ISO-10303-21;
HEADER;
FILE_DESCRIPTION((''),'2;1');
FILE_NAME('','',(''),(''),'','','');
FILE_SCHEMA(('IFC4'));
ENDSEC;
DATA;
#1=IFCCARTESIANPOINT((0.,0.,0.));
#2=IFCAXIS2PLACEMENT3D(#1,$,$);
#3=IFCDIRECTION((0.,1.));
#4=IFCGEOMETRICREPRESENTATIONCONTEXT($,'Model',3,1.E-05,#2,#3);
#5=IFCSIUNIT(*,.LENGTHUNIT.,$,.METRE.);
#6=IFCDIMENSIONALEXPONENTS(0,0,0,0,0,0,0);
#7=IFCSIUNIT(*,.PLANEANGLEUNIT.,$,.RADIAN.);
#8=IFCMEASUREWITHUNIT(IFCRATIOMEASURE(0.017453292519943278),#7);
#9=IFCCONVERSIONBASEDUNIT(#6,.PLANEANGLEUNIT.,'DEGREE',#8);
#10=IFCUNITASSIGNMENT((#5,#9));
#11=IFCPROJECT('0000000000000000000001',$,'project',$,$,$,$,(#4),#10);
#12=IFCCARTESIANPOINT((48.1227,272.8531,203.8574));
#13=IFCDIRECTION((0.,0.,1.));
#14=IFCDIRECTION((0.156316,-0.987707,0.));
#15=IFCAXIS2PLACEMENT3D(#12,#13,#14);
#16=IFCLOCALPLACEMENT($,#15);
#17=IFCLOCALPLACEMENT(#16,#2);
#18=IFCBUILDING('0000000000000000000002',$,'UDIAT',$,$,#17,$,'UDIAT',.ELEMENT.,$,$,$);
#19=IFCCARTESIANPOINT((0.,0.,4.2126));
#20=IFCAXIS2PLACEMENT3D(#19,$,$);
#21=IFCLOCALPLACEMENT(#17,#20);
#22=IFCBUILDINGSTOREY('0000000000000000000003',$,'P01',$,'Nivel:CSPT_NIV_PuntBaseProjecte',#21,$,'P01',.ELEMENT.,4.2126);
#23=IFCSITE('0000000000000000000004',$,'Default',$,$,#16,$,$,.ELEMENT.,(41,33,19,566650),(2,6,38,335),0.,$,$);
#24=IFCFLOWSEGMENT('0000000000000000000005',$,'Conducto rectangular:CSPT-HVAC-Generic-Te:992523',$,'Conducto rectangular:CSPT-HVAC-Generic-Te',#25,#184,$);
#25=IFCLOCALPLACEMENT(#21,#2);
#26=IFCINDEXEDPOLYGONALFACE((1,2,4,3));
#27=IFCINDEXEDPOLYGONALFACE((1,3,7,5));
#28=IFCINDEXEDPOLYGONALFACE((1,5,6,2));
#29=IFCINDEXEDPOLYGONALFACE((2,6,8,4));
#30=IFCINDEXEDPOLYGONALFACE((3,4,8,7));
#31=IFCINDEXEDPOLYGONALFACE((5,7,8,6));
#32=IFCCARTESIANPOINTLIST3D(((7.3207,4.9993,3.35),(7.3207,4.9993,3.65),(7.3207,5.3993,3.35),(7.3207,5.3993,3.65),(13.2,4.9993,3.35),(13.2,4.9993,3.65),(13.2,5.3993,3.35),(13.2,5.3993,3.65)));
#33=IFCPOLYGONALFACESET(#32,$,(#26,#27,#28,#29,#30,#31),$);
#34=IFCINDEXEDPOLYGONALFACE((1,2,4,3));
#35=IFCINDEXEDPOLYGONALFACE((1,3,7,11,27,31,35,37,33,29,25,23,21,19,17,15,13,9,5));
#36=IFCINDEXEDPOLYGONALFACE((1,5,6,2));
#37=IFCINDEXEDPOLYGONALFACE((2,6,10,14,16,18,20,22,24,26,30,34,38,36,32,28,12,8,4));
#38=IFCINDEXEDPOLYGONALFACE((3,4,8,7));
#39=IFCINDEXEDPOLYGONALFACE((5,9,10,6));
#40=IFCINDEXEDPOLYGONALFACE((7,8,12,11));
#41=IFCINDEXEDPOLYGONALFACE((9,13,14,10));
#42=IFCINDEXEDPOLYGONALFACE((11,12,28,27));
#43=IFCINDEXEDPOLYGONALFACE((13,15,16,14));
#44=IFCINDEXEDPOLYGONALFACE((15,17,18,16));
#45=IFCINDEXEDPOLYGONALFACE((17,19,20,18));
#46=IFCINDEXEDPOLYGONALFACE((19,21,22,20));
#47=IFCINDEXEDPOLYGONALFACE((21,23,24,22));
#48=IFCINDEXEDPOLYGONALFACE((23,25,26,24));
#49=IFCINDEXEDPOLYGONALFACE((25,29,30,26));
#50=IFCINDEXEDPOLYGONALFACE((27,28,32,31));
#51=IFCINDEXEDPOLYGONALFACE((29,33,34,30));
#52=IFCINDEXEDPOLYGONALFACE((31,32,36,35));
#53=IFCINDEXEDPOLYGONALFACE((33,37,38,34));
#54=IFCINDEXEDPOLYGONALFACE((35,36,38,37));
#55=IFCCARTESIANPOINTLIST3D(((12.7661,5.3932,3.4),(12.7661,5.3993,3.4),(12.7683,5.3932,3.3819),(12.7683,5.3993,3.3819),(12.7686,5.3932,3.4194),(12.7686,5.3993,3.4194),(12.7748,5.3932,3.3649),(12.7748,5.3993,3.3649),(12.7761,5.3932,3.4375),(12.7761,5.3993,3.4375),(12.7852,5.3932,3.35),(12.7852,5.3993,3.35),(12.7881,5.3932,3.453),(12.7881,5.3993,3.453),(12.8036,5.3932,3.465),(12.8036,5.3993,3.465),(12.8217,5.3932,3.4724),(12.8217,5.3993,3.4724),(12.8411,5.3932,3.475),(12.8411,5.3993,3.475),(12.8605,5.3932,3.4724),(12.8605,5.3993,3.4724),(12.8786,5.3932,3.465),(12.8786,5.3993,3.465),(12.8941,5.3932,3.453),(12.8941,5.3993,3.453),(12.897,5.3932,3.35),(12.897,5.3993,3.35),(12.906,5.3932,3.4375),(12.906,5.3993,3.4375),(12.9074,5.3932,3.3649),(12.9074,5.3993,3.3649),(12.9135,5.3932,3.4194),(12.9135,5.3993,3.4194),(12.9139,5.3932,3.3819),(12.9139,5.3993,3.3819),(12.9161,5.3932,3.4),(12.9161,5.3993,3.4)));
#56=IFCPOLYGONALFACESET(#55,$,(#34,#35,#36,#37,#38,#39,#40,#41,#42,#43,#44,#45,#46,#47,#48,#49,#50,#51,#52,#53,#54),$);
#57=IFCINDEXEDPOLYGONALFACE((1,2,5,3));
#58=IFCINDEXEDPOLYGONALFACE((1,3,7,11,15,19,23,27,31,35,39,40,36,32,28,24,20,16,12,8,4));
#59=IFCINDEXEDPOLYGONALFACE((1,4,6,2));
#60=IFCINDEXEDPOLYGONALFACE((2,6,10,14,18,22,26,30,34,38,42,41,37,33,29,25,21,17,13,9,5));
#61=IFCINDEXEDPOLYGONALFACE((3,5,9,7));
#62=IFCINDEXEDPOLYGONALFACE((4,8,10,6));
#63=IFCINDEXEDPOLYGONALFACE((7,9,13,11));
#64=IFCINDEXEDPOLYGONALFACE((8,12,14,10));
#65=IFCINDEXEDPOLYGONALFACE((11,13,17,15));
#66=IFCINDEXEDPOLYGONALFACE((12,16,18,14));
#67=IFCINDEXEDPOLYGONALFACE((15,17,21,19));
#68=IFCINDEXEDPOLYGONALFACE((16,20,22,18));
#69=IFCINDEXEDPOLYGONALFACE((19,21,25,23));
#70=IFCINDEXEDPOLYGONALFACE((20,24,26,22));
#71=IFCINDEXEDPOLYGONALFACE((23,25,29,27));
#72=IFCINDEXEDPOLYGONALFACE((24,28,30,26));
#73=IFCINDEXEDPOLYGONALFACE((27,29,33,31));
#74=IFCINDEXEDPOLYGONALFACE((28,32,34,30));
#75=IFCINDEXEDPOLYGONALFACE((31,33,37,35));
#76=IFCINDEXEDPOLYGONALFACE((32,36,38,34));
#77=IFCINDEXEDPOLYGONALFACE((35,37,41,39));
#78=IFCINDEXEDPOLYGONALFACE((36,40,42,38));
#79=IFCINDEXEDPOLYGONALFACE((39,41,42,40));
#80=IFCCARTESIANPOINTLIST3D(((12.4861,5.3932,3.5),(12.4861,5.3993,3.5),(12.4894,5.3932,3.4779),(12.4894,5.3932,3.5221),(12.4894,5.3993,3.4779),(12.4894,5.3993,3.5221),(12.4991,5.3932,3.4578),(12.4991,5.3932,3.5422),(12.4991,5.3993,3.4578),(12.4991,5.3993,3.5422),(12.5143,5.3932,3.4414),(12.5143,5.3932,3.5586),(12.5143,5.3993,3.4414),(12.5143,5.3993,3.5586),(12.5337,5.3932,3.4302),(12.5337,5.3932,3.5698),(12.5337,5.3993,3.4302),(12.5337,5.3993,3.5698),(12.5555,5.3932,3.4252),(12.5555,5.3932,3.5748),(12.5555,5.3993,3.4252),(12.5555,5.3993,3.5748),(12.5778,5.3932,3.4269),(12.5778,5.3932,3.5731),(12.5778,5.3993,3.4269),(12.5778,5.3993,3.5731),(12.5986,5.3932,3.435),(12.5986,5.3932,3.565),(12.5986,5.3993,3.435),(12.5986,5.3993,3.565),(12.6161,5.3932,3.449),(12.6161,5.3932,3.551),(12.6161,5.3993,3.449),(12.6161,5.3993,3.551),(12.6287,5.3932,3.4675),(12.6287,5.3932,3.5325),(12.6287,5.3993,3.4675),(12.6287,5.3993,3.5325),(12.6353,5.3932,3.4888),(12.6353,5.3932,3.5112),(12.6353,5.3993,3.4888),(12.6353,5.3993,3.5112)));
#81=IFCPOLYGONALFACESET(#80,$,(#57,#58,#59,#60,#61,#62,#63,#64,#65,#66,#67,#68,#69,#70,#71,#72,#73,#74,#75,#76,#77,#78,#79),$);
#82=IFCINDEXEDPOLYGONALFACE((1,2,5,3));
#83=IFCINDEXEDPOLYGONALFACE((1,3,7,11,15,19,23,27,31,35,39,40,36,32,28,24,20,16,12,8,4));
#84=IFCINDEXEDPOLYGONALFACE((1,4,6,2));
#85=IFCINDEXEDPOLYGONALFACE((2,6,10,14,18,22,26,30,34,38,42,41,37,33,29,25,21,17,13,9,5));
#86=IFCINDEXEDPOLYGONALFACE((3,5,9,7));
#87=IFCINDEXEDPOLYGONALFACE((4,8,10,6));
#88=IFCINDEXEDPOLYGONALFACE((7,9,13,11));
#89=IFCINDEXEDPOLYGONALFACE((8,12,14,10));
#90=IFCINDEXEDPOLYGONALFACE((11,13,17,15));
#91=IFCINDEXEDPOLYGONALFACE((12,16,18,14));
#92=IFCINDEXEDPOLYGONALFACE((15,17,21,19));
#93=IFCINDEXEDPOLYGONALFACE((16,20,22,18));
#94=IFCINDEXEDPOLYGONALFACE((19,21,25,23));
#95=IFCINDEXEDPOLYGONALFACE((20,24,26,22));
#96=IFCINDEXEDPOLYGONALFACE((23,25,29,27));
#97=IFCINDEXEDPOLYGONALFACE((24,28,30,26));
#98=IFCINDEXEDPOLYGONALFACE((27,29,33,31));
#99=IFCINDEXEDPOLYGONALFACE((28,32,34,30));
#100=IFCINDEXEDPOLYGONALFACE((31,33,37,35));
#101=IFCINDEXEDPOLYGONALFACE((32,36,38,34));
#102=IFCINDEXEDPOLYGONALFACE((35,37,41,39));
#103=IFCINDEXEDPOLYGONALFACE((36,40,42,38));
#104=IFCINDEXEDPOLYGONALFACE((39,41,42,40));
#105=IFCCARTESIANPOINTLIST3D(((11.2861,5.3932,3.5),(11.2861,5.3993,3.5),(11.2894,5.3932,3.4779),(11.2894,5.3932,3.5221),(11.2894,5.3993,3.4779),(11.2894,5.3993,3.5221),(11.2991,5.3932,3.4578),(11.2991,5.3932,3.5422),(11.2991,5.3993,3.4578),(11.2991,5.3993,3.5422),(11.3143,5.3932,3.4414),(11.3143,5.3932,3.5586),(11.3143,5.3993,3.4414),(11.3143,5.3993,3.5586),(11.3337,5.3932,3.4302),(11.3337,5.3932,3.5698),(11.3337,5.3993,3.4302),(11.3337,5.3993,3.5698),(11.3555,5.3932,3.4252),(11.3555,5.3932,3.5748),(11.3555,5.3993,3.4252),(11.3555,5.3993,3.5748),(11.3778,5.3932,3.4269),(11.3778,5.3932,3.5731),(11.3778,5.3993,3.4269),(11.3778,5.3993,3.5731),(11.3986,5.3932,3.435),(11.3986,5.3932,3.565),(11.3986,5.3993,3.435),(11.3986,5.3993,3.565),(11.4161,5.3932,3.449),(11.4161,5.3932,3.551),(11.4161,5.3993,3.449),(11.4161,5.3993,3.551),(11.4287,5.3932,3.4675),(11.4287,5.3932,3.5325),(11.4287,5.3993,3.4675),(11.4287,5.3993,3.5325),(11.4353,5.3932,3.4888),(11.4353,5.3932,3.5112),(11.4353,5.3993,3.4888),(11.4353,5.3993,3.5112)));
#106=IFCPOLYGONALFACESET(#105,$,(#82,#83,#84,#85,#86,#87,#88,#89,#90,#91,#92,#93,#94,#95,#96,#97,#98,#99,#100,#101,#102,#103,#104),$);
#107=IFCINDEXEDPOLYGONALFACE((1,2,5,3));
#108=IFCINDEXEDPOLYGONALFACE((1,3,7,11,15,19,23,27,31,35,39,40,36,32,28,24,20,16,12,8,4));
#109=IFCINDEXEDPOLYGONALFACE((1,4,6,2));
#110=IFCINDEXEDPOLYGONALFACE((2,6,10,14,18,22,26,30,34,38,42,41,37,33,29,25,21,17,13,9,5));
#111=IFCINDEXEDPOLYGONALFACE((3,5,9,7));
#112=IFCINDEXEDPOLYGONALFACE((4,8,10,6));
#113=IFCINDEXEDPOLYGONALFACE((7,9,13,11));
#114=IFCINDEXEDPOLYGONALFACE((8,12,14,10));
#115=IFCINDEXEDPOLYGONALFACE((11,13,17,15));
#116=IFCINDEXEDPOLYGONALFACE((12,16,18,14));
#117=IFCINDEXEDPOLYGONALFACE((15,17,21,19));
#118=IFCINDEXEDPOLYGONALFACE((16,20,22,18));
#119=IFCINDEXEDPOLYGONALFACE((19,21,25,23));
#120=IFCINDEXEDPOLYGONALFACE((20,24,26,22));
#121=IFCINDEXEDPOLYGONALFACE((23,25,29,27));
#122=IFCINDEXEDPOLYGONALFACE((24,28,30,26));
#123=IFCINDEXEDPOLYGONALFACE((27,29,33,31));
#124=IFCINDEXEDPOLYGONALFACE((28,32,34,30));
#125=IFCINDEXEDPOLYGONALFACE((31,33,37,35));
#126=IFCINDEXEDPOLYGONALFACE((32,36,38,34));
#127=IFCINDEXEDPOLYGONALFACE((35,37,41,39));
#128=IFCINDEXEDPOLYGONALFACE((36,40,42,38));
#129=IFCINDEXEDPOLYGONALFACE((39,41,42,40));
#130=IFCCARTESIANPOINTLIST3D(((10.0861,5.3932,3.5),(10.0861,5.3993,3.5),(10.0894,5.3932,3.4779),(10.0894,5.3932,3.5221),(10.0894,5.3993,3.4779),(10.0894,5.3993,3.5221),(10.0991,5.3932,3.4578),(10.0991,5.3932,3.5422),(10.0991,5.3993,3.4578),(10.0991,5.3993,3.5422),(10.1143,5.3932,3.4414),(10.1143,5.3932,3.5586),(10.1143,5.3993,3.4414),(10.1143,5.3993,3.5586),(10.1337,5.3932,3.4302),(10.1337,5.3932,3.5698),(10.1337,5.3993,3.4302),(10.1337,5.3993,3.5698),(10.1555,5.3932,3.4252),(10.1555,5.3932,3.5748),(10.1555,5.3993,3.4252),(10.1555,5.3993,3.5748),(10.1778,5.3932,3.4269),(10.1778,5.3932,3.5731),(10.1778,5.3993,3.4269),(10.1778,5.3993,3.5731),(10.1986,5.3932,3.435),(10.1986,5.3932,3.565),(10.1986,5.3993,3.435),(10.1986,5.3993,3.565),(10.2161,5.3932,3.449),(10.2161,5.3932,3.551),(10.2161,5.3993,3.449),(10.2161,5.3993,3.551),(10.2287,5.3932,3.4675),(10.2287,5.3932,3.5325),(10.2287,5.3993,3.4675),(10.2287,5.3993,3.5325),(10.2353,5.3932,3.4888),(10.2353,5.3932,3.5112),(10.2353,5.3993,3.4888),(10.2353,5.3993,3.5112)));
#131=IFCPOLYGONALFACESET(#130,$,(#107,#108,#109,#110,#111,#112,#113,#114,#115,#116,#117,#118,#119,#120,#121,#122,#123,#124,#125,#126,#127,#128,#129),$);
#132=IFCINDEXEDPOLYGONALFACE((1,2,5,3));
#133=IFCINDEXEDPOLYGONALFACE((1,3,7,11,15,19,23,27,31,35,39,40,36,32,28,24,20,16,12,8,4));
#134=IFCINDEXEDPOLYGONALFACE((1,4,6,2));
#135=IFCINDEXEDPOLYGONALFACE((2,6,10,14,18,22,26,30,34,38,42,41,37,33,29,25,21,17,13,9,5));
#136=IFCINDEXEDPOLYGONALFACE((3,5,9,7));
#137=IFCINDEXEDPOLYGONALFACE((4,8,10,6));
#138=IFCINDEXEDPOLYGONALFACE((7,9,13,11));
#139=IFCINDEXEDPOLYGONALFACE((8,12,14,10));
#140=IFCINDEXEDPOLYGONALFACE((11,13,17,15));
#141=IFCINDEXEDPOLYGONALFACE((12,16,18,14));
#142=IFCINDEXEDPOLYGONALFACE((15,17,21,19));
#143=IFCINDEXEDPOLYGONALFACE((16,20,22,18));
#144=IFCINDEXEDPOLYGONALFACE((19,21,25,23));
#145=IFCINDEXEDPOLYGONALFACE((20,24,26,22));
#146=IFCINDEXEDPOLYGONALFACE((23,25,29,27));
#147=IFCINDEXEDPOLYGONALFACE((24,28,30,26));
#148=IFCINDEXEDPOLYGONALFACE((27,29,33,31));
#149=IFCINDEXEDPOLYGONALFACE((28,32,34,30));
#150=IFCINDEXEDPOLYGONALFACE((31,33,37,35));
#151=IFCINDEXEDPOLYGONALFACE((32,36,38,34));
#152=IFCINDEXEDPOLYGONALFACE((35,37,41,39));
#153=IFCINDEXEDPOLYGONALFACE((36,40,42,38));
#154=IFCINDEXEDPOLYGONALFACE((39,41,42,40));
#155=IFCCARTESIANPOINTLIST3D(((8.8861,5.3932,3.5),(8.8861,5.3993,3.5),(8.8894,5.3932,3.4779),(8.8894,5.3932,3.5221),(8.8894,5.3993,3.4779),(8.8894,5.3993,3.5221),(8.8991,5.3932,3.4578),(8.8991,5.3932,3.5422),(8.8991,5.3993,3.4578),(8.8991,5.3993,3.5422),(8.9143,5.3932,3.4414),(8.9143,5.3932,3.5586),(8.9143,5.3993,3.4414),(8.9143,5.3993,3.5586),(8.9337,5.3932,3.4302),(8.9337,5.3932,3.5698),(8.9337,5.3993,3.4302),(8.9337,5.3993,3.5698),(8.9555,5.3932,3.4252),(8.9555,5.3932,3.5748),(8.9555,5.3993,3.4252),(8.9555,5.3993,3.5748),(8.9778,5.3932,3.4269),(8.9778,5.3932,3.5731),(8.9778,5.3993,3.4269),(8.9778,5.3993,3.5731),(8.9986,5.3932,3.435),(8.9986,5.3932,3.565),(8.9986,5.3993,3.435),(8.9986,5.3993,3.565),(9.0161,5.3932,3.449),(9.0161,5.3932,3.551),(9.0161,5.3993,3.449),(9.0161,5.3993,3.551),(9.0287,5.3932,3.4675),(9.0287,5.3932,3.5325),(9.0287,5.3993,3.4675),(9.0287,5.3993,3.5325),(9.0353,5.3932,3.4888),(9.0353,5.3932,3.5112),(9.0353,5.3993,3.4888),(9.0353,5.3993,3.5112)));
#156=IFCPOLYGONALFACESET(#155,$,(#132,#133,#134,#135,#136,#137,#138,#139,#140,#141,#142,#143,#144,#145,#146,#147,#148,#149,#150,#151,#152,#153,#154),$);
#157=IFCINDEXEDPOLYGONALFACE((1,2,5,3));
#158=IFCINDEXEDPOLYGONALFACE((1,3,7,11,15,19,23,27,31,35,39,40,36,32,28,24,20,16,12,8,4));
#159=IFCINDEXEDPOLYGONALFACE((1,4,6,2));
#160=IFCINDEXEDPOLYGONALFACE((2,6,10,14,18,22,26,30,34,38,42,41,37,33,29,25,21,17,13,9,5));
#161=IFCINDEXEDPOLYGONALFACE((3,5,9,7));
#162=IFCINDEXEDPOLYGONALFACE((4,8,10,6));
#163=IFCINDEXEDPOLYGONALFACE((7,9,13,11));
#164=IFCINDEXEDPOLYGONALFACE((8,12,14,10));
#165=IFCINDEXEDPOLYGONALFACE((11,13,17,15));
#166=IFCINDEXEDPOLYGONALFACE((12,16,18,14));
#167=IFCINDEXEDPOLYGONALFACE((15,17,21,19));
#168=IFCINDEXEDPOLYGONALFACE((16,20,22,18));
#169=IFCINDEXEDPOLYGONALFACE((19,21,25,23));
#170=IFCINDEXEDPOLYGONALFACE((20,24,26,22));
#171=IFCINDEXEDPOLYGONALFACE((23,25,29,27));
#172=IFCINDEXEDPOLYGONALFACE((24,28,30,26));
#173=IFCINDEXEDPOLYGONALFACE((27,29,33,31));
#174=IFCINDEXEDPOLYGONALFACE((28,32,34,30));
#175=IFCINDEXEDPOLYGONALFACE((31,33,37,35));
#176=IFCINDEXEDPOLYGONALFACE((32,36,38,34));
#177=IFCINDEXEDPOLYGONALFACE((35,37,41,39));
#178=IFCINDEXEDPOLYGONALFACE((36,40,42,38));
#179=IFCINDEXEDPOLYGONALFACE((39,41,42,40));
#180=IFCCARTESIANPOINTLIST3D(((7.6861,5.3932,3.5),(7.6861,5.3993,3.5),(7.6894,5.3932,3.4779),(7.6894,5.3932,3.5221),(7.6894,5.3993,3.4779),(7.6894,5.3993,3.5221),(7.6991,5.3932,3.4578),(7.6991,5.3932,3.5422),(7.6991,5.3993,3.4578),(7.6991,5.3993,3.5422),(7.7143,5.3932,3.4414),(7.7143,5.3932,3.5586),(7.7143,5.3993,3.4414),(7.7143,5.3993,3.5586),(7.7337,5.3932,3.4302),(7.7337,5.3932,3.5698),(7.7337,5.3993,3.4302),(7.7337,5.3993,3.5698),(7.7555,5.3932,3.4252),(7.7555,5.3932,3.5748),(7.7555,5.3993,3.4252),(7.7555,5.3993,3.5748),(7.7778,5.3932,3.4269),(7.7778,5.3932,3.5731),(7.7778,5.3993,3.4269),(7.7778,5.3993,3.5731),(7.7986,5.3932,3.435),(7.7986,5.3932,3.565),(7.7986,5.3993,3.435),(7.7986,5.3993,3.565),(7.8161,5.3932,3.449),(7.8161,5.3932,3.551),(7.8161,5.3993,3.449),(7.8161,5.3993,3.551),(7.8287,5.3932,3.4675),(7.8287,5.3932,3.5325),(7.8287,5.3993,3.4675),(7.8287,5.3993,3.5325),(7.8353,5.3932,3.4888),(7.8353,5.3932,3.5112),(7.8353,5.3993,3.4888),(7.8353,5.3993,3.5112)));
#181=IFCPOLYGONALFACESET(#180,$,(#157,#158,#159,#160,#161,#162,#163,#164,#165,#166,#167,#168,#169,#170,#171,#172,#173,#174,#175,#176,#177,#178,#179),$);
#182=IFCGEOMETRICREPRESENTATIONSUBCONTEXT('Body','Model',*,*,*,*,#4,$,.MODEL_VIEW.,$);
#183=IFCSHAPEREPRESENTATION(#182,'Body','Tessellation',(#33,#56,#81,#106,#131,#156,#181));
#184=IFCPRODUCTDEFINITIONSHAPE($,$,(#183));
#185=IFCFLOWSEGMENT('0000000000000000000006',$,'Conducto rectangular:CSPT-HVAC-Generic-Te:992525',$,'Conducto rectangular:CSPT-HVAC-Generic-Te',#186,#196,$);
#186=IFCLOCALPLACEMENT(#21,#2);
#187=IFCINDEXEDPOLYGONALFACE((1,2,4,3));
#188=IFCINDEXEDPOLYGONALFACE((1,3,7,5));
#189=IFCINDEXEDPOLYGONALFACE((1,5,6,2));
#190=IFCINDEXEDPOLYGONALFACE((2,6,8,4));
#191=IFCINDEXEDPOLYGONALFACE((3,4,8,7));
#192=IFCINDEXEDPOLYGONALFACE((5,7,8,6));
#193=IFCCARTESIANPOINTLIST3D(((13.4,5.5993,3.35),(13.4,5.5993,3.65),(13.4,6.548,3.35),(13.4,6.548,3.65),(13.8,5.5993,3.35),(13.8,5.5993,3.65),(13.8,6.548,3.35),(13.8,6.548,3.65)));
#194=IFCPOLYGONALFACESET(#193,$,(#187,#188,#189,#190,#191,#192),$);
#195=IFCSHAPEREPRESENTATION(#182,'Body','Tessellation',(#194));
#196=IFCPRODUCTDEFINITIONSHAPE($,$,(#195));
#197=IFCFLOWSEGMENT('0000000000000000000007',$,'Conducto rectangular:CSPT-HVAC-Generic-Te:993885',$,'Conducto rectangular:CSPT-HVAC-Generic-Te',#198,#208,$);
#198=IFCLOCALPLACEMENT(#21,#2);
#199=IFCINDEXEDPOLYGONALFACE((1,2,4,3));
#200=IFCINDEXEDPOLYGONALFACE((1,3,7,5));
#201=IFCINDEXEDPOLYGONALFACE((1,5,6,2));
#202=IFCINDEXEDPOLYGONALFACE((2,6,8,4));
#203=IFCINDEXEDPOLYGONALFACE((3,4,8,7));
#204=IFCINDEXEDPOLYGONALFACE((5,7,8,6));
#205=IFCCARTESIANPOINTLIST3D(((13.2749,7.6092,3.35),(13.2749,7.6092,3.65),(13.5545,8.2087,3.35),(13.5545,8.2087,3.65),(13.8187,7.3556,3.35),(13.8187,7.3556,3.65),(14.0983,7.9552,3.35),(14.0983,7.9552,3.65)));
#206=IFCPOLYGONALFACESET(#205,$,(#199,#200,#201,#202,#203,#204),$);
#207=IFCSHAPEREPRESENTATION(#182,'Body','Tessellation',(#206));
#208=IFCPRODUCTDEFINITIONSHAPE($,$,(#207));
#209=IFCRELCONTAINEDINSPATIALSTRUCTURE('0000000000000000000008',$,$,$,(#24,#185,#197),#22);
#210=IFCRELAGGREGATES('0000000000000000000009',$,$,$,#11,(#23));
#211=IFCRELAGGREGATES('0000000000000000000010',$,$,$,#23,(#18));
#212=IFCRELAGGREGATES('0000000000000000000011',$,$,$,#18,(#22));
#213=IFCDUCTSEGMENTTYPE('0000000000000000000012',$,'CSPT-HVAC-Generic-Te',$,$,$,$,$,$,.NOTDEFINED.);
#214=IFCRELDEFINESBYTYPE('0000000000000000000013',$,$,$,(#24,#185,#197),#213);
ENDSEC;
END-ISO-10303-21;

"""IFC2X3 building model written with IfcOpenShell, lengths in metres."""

from ifc_helpers import new_model, entity, si_unit, converted_unit, direction, frame, frame_2d, origin, origin_2d_with_axis, place, context, subcontext, project, spatial, polyline, circle_curve, parameter, trimmed, segment, composite_curve, rectangle, circle, outline, extrude, type_object, element, save


model = new_model("IFC2X3")

# Units and contexts
model_context = context("Model", 3, precision=1e-05, world=origin(), true_north=direction((0.0, 1.0)))
body_context = subcontext(model_context, "Body", "Model", "MODEL_VIEW")
ifc_project = project(units=[si_unit("LENGTHUNIT", "METRE"), converted_unit("PLANEANGLEUNIT", "DEGREE", entity("IfcRatioMeasure", 0.017453292519943278), si_unit("PLANEANGLEUNIT", "RADIAN"), dimensions=[0, 0, 0, 0, 0, 0, 0])], contexts=[model_context])

# Site, building, storey
site_placement = place(None, frame((48.1227, 272.8531, 203.8574), z_axis=(0.0, 0.0, 1.0), x_axis=(0.156316, -0.987707, 0.0)))
site = spatial("IfcSite", under=ifc_project, at=site_placement, Name="Default", CompositionType="ELEMENT", RefLatitude=(41, 33, 19, 566650), RefLongitude=(2, 6, 38, 335), RefElevation=0.0)
building_placement = place(site_placement, origin())
building = spatial("IfcBuilding", under=site, at=building_placement, Name="UDIAT", LongName="UDIAT", CompositionType="ELEMENT")
storey_placement = place(building_placement, frame((0.0, 0.0, 4.2126)))
storey = spatial("IfcBuildingStorey", under=building, at=storey_placement, Name="P01", ObjectType="Nivel:CSPT_NIV_PuntBaseProjecte", LongName="P01", CompositionType="ELEMENT", Elevation=4.2126)

# Flow segments
duct_segment_type = type_object("IfcDuctSegmentType", Name="CSPT-HVAC-Generic-Te", PredefinedType="NOTDEFINED")
flow_segment_1_placement = place(storey_placement, origin())
element("IfcFlowSegment", 1, at=flow_segment_1_placement, inside=storey, type_object=duct_segment_type, Name="Conducto rectangular:CSPT-HVAC-Generic-Te:992523", ObjectType="Conducto rectangular:CSPT-HVAC-Generic-Te", context=body_context, shape_type="SweptSolid", body=[
    extrude(rectangle(XDim=5.8793, YDim=0.4, at=frame_2d((0.0, 0.0), x_axis=(1.0, 0.0))), frame((10.2604, 5.1993, 3.35)), (0.0, 0.0, 1.0), 0.3),
    extrude(outline(composite_curve([segment(trimmed(circle_curve(frame_2d((0.0, 0.005), x_axis=(1.0, 0.0)), 0.075), [parameter(90.0)], [parameter(180.0)], True, "PARAMETER"), True, "CONTINUOUS"), segment(trimmed(circle_curve(frame_2d((0.0, 0.005), x_axis=(1.0, 0.0)), 0.075), [parameter(180.0)], [parameter(221.810315)], True, "PARAMETER"), True, "CONTINUOUS"), segment(polyline([(-0.0559, -0.045), (0.0559, -0.045)]), True, "CONTINUOUS"), segment(trimmed(circle_curve(frame_2d((0.0, 0.005), x_axis=(1.0, 0.0)), 0.075), [parameter(318.189685)], [parameter(0.0)], True, "PARAMETER"), True, "CONTINUOUS"), segment(trimmed(circle_curve(frame_2d((0.0, 0.005), x_axis=(1.0, 0.0)), 0.075), [parameter(0.0)], [parameter(90.0)], True, "PARAMETER"), True, "CONTINUOUS")], self_intersect=False)), frame((12.8411, 5.3932, 3.395), z_axis=(0.0, 1.0, 0.0), x_axis=(-1.0, 0.0, 0.0)), (0.0, 0.0, 1.0), 0.0061),
    extrude(circle(Radius=0.075, at=origin_2d_with_axis()), frame((12.5611, 5.3932, 3.5), z_axis=(0.0, 1.0, 0.0), x_axis=(-1.0, 0.0, 0.0)), (0.0, 0.0, 1.0), 0.0061),
    extrude(circle(Radius=0.075, at=frame_2d((0.0, 0.0), x_axis=(1.0, 0.0))), frame((11.3611, 5.3932, 3.5), z_axis=(0.0, 1.0, 0.0), x_axis=(-1.0, 0.0, 0.0)), (0.0, 0.0, 1.0), 0.0061),
    extrude(circle(Radius=0.075, at=origin_2d_with_axis()), frame((10.1611, 5.3932, 3.5), z_axis=(0.0, 1.0, 0.0), x_axis=(-1.0, 0.0, 0.0)), (0.0, 0.0, 1.0), 0.0061),
    extrude(circle(Radius=0.075, at=frame_2d((0.0, 0.0), x_axis=(1.0, 0.0))), frame((8.9611, 5.3932, 3.5), z_axis=(0.0, 1.0, 0.0), x_axis=(-1.0, 0.0, 0.0)), (0.0, 0.0, 1.0), 0.0061),
    extrude(circle(Radius=0.075, at=frame_2d((0.0, 0.0), x_axis=(1.0, 0.0))), frame((7.7611, 5.3932, 3.5), z_axis=(0.0, 1.0, 0.0), x_axis=(-1.0, 0.0, 0.0)), (0.0, 0.0, 1.0), 0.0061),
])
flow_segment_2_placement = place(storey_placement, origin())
element("IfcFlowSegment", 2, at=flow_segment_2_placement, inside=storey, type_object=duct_segment_type, Name="Conducto rectangular:CSPT-HVAC-Generic-Te:992525", ObjectType="Conducto rectangular:CSPT-HVAC-Generic-Te", context=body_context, shape_type="SweptSolid", body=[
    extrude(rectangle(XDim=0.9487, YDim=0.4, at=frame_2d((0.0, 0.0), x_axis=(1.0, 0.0))), frame((13.6, 6.0736, 3.35), z_axis=(0.0, 0.0, 1.0), x_axis=(0.0, 1.0, 0.0)), (0.0, 0.0, 1.0), 0.3),
])
flow_segment_3_placement = place(storey_placement, origin())
element("IfcFlowSegment", 3, at=flow_segment_3_placement, inside=storey, type_object=duct_segment_type, Name="Conducto rectangular:CSPT-HVAC-Generic-Te:993885", ObjectType="Conducto rectangular:CSPT-HVAC-Generic-Te", context=body_context, shape_type="SweptSolid", body=[
    extrude(rectangle(XDim=0.6616, YDim=0.6, at=frame_2d((0.0, 0.0), x_axis=(1.0, 0.0))), frame((13.6866, 7.7822, 3.35), z_axis=(0.0, 0.0, 1.0), x_axis=(-0.422618, -0.906308, 0.0)), (0.0, 0.0, 1.0), 0.3),
])

save(model, "model.ifc")
